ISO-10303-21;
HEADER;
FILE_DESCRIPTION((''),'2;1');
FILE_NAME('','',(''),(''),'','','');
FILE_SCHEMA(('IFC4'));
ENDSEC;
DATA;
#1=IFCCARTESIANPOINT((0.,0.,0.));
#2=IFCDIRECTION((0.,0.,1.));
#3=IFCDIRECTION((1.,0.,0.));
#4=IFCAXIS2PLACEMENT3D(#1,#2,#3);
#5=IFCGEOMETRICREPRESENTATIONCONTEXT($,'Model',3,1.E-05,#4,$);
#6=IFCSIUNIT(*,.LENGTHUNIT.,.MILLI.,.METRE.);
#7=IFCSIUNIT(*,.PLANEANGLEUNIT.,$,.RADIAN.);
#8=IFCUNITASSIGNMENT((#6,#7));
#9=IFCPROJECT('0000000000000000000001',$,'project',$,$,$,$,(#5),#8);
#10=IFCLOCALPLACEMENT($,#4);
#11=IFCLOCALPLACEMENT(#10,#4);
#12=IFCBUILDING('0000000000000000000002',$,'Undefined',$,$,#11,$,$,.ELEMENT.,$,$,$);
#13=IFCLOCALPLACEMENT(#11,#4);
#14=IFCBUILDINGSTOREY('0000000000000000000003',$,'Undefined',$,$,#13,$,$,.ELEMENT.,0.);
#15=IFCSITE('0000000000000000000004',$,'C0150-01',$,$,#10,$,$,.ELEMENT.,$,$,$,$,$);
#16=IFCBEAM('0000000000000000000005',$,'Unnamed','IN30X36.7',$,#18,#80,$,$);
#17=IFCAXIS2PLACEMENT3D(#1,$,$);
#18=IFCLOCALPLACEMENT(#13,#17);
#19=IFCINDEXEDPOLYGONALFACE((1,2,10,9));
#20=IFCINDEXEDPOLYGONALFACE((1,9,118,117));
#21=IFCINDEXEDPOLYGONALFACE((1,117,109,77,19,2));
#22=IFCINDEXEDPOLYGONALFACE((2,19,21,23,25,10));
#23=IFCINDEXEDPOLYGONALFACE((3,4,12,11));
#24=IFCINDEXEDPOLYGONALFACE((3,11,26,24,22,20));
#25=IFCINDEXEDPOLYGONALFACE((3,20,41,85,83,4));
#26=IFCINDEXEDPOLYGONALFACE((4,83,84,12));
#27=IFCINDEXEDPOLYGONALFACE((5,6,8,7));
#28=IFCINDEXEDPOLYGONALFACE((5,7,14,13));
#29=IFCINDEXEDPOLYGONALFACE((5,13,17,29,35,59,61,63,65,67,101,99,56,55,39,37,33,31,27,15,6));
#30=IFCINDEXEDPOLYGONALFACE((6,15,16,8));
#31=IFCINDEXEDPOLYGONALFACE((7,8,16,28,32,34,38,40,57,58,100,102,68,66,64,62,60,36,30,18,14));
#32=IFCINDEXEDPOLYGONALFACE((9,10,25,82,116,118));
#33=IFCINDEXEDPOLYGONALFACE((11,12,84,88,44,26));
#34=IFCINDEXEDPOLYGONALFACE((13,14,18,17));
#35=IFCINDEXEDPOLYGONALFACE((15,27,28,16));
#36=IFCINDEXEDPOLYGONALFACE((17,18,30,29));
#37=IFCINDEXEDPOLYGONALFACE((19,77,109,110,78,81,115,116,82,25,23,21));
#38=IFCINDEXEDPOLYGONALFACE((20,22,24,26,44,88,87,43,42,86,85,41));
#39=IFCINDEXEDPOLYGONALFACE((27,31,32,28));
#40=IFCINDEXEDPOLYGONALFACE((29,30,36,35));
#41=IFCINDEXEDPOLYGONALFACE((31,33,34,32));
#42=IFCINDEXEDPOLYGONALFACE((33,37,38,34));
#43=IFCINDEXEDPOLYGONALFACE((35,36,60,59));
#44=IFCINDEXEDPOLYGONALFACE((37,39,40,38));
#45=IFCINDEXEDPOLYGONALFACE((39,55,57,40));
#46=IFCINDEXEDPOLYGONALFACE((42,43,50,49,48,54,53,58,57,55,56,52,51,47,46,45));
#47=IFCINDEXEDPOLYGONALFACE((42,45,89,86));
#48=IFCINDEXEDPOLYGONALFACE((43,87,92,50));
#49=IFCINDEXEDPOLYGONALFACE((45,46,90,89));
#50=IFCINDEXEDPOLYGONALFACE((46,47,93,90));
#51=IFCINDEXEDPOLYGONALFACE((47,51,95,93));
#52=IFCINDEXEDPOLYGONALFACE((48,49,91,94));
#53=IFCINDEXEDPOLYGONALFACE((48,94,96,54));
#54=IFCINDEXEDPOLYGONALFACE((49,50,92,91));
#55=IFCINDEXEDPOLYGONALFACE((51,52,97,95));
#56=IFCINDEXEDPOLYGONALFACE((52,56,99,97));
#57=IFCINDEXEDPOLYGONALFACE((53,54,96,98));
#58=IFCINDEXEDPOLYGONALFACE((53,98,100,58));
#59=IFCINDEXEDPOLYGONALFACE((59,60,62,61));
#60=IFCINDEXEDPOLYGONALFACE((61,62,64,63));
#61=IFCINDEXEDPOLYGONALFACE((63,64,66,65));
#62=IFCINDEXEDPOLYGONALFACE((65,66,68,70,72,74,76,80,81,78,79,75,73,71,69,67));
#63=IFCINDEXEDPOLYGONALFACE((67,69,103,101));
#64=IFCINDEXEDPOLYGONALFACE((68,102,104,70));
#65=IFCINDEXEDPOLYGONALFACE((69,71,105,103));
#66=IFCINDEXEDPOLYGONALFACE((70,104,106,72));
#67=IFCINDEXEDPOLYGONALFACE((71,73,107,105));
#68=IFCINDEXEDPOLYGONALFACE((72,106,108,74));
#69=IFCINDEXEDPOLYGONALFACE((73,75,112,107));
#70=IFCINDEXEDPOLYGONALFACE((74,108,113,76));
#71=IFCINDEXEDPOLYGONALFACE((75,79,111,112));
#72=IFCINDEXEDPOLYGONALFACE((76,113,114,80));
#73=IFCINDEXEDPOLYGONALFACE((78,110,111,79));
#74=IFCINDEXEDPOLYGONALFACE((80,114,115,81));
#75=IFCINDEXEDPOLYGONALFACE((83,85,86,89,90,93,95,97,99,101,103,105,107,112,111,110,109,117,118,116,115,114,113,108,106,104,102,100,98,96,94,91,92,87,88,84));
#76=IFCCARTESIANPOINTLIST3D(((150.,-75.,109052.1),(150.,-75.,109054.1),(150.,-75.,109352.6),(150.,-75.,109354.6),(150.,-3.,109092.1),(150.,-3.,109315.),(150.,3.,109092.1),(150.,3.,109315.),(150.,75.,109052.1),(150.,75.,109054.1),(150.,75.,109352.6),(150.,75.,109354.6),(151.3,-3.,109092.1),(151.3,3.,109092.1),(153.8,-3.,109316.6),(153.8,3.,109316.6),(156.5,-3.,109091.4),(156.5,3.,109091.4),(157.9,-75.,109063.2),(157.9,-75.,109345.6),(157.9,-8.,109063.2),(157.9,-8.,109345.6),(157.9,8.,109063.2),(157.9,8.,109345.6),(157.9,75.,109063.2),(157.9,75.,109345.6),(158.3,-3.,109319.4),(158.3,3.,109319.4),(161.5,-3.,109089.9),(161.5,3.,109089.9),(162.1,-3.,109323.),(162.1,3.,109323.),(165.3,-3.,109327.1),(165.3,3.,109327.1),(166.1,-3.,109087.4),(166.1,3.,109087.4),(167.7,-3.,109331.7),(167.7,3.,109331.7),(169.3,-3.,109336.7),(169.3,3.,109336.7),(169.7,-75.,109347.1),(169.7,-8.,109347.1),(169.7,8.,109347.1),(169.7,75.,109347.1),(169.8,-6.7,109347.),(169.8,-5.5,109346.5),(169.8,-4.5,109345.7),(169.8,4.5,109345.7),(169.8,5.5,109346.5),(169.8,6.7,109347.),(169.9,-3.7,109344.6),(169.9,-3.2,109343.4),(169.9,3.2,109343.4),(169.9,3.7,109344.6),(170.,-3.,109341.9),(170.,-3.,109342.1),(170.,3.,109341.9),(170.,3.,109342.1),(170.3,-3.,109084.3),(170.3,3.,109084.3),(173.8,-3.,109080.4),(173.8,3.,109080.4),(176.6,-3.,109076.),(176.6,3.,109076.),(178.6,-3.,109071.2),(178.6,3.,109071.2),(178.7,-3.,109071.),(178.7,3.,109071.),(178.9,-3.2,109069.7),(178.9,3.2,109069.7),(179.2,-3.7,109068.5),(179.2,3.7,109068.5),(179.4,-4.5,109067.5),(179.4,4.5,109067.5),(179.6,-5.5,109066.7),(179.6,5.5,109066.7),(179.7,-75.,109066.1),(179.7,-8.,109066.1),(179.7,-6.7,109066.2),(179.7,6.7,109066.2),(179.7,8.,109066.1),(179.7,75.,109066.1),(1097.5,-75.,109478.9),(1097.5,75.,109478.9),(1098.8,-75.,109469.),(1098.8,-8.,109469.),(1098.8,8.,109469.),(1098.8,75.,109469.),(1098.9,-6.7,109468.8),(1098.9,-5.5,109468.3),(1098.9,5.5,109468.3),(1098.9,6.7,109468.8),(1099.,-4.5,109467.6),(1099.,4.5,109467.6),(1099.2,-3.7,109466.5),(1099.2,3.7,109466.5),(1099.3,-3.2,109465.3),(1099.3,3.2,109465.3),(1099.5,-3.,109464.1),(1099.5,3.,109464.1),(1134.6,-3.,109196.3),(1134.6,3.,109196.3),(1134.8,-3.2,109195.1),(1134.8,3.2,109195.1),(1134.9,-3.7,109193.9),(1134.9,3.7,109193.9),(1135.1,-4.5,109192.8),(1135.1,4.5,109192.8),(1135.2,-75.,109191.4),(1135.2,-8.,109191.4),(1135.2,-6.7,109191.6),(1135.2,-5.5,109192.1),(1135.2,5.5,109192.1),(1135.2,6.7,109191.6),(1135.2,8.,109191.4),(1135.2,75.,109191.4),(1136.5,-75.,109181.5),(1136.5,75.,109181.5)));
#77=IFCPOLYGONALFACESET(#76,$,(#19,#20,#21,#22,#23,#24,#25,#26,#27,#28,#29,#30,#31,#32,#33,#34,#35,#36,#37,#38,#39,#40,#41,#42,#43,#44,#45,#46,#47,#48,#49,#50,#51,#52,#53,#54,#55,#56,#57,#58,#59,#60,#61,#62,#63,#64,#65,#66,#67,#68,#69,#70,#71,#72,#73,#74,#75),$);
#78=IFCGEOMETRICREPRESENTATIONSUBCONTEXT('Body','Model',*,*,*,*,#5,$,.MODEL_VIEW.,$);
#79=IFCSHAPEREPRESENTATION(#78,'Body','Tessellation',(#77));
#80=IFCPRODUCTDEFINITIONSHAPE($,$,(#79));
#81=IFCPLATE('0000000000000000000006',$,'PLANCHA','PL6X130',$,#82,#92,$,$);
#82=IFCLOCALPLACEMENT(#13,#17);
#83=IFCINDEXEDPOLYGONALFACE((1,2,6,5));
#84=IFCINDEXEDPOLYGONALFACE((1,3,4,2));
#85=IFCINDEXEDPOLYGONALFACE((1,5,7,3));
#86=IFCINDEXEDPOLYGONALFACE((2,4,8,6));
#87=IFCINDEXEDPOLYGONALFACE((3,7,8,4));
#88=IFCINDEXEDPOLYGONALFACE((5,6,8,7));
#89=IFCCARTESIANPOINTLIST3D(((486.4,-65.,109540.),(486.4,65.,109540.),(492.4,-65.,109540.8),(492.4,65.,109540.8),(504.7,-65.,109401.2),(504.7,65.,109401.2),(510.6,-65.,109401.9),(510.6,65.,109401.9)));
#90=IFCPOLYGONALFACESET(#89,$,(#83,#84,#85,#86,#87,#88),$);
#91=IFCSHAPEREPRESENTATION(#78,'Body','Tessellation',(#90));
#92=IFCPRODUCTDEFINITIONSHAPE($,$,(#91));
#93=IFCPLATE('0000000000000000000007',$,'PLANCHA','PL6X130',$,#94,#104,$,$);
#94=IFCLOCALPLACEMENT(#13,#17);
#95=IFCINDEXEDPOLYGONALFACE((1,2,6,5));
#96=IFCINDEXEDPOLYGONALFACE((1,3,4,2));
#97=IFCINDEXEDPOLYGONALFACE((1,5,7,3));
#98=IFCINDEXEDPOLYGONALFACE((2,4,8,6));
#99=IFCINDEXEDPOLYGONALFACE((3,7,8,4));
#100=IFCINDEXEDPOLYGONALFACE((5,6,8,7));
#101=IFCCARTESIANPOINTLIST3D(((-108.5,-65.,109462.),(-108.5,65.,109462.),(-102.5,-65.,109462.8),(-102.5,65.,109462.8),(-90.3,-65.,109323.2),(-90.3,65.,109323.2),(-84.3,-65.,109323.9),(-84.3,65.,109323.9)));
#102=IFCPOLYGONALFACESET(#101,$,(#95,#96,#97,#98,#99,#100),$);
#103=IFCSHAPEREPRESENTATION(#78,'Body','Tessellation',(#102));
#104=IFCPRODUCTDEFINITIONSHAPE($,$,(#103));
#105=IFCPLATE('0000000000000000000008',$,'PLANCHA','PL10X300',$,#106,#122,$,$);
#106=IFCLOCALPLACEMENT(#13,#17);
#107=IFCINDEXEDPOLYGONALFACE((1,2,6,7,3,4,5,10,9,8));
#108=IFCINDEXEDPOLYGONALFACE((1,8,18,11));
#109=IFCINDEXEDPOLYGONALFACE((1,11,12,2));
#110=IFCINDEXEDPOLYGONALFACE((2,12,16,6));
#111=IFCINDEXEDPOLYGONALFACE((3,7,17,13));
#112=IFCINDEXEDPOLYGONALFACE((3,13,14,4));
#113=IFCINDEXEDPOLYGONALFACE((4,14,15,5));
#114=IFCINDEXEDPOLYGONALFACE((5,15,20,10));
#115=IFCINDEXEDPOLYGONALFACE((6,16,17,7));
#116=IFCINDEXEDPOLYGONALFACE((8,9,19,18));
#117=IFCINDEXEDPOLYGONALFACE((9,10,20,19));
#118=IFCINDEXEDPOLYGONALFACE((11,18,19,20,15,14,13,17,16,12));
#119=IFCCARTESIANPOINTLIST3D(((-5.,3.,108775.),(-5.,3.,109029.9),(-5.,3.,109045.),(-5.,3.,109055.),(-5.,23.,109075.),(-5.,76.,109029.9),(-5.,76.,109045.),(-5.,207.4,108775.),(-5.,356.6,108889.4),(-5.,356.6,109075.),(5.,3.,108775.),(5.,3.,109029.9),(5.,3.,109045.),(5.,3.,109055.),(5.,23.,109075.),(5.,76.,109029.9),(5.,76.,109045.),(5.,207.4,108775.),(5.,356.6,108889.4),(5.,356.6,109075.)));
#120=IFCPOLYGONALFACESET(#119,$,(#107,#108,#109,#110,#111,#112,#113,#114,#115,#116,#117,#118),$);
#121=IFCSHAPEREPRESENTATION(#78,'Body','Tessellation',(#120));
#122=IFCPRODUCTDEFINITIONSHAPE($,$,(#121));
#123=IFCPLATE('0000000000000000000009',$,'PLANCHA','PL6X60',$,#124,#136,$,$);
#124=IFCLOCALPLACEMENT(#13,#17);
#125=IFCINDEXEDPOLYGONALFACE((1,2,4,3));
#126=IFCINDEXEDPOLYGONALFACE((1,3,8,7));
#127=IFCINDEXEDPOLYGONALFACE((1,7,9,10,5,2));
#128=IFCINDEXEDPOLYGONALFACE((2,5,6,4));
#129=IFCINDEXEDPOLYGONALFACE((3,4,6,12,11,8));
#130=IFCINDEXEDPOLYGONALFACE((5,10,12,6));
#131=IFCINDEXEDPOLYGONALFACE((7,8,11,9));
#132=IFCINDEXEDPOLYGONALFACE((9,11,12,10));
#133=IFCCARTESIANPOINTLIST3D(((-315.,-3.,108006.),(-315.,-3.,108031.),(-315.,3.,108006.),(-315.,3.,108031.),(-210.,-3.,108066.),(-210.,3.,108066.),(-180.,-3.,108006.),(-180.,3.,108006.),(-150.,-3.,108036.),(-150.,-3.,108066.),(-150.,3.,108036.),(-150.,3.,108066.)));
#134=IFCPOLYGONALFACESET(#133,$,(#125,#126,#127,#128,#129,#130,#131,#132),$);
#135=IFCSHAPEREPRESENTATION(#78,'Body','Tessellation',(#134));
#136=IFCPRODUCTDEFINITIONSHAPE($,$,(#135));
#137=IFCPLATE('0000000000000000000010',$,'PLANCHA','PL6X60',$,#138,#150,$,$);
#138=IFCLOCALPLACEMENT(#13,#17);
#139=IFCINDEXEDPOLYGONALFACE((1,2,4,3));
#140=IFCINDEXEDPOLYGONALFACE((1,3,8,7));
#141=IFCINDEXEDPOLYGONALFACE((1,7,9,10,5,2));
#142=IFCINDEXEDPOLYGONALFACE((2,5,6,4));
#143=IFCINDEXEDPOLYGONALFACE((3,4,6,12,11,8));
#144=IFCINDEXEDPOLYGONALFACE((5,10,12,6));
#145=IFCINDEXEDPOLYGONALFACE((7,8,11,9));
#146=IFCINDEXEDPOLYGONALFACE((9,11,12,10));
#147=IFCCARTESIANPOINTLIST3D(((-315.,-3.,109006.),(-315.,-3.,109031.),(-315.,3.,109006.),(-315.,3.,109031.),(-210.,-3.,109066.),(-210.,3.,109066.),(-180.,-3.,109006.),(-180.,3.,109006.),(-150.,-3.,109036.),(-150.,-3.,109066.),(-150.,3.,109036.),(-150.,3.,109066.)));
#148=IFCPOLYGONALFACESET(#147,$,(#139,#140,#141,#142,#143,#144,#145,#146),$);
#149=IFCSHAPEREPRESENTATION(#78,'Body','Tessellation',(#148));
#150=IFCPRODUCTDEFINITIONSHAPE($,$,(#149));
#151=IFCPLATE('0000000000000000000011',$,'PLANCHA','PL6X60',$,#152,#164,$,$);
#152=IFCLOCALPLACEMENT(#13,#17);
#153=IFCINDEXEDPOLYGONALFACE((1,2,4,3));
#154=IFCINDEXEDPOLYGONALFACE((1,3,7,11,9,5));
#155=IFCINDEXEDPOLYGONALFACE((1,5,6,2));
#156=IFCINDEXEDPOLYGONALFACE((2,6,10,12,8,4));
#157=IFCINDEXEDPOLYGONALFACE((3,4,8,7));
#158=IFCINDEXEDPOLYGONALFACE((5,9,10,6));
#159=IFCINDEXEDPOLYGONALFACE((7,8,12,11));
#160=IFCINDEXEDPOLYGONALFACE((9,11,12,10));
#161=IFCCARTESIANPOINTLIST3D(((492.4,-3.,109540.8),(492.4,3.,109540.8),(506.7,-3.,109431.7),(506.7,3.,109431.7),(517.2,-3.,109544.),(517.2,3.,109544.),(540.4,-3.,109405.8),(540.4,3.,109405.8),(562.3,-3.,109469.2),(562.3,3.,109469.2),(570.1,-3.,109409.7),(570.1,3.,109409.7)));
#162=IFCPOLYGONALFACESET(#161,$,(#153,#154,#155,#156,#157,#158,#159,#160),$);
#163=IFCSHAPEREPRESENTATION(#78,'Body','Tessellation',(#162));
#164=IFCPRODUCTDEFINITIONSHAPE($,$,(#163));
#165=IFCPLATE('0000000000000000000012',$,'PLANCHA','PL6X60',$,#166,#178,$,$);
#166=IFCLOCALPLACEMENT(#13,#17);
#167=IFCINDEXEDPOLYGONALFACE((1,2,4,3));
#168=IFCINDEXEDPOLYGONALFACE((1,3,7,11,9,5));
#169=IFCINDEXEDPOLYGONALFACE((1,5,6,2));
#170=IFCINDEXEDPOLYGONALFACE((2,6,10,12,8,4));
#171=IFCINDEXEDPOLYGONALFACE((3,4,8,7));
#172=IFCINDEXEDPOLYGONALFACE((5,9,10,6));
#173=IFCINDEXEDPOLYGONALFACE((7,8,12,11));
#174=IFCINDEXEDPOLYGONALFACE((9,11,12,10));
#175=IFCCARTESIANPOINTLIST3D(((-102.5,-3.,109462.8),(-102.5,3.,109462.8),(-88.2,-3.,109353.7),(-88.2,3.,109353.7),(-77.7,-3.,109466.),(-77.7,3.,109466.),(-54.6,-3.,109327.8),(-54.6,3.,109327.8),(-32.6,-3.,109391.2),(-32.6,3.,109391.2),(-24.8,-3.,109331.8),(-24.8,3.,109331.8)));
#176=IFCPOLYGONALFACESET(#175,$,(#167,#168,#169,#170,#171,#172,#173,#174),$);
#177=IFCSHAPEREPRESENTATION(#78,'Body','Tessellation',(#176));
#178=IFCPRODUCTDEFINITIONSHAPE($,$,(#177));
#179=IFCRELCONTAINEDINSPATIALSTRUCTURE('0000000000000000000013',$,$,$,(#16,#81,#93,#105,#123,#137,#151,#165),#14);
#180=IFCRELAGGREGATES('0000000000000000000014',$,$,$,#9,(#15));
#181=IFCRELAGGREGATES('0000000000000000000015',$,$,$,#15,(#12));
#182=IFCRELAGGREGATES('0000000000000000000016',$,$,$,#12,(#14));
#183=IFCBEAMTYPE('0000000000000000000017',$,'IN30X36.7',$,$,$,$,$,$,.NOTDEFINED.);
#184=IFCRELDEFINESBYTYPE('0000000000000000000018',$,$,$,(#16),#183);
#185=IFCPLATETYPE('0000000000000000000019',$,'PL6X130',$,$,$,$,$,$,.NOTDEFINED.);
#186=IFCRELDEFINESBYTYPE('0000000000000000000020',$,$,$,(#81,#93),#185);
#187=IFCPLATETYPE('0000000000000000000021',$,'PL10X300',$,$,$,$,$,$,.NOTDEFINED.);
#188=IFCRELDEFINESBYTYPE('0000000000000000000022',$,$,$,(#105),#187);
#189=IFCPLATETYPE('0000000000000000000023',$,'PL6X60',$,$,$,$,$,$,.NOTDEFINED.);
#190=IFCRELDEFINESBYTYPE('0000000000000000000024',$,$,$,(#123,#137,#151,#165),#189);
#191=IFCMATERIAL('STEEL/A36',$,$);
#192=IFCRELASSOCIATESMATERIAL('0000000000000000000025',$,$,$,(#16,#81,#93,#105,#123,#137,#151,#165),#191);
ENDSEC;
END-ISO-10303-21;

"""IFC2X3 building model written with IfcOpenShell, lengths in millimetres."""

from ifc_helpers import new_model, si_unit, frame, origin_with_axes, origin_2d_with_axis, place, context, subcontext, project, spatial, polyline, i_section, outline, extrude, boolean, halfspace, material, type_object, element, save


model = new_model("IFC2X3")

# Units and contexts
model_context = context("Model", 3, precision=1e-05, world=origin_with_axes())
body_context = subcontext(model_context, "Body", "Model", "MODEL_VIEW")
ifc_project = project(units=[si_unit("LENGTHUNIT", "METRE", prefix="MILLI"), si_unit("PLANEANGLEUNIT", "RADIAN")], contexts=[model_context])

# Site, building, storey
site_placement = place(None, origin_with_axes())
site = spatial("IfcSite", under=ifc_project, at=site_placement, Name="C0150-01", CompositionType="ELEMENT")
building_placement = place(site_placement, origin_with_axes())
building = spatial("IfcBuilding", under=site, at=building_placement, Name="Undefined", CompositionType="ELEMENT")
storey_placement = place(building_placement, origin_with_axes())
storey = spatial("IfcBuildingStorey", under=building, at=storey_placement, Name="Undefined", CompositionType="ELEMENT", Elevation=0.0)

# Shared definitions
ifc_material_1 = material(Name="STEEL/A36")

# Beam
beam_type_1 = type_object("IfcBeamType", Name="IN30X36.7", PredefinedType="NOTDEFINED")
beam_1_placement = place(storey_placement, frame((0.0, 0.0, 109183.7), z_axis=(-0.130054, 0.0, 0.991507), x_axis=(0.991507, 0.0, 0.130054)))
element("IfcBeam", 1, at=beam_1_placement, inside=storey, type_object=beam_type_1, material=ifc_material_1, Name="Unnamed", Description="IN30X36.7", context=body_context, shape_type="CSG", body=[
    boolean("DIFFERENCE", boolean("DIFFERENCE", boolean("DIFFERENCE", boolean("DIFFERENCE", boolean("DIFFERENCE", extrude(i_section(OverallWidth=150.0, OverallDepth=300.0, WebThickness=6.0, FlangeThickness=10.0, FilletRadius=5.0, at=origin_2d_with_axis()), frame((1126.6, 0.0, 0.0), z_axis=(-1.0, 0.0, 0.0), x_axis=(0.0, -1.0, 0.0)), (0.0, 0.0, 1.0), 1126.6), extrude(outline(polyline([(0.0, 0.0), (12.1, 0.0), (6.0, 5.3), (0.0, 0.0)])), frame((140.9, -77.5, -140.0), z_axis=(0.0, 1.0, 0.0), x_axis=(-0.748593, 0.0, -0.66303)), (0.0, 0.0, 1.0), 155.0)), extrude(outline(polyline([(0.0, 0.0), (8.0, 0.0), (6.9, 8.0), (0.0, 0.0)])), frame((177.6, -77.5, 140.0), z_axis=(0.0, 1.0, 0.0), x_axis=(-1.0, 0.0, 0.0)), (0.0, 0.0, 1.0), 155.0)), extrude(outline(polyline([(0.0, 0.0), (30.0, 0.0), (30.0, 0.0), (29.5, 5.2), (28.2, 10.3), (26.0, 15.0), (23.0, 19.3), (19.3, 23.0), (15.0, 26.0), (10.3, 28.2), (5.2, 29.5), (0.0, 30.0), (3.9, 30.0), (0.0, 0.0)])), frame((159.6, -77.5, 140.0), z_axis=(0.0, 1.0, 0.0), x_axis=(1.0, 0.0, 0.0)), (0.0, 0.0, 1.0), 155.0)), extrude(outline(polyline([(0.0, 0.0), (30.0, 0.0), (30.0, 0.0), (29.5, 5.2), (28.2, 10.3), (26.0, 15.0), (23.0, 19.3), (19.3, 23.0), (15.0, 26.0), (10.3, 28.2), (5.2, 29.5), (0.0, 30.0), (3.9, 30.0), (0.0, 0.0)])), frame((132.9, 77.5, -140.0), z_axis=(0.0, -1.0, 0.0), x_axis=(1.0, 0.0, 0.0)), (0.0, 0.0, 1.0), 155.0)), halfspace(frame((124.8, 0.0, -201.6), z_axis=(0.991507, 0.0, -0.130054), x_axis=(0.0, -1.0, 0.0)), True)),
])

# Plates
plate_type_1 = type_object("IfcPlateType", Name="PL6X130", PredefinedType="NOTDEFINED")
for number, where, z_axis, x_axis, name in (
    (2, (507.6, -65.0, 109401.5), (0.991507, 0.0, 0.130054), (0.0, 1.0, 0.0), "PLANCHA"),
    (3, (-87.3, 65.0, 109323.6), (-0.991507, 0.0, -0.130054), (0.0, -1.0, 0.0), "PLANCHA"),
):
    element("IfcPlate", number, at=place(storey_placement, frame(where, z_axis=z_axis, x_axis=x_axis)), inside=storey, type_object=plate_type_1, material=ifc_material_1, Name=name, Description="PL6X130", context=body_context, shape_type="SweptSolid", body=[
        extrude(outline(polyline([(0.0, 0.0), (130.0, 0.0), (130.0, 140.0), (0.0, 140.0), (0.0, 0.0)])), frame((0.0, 0.0, -3.0), z_axis=(0.0, 0.0, 1.0), x_axis=(1.0, 0.0, 0.0)), (0.0, 0.0, 1.0), 6.0),
    ])
plate_type_2 = type_object("IfcPlateType", Name="PL10X300", PredefinedType="NOTDEFINED")
plate_1_placement = place(storey_placement, frame((0.0, 356.6, 109075.0), z_axis=(-1.0, 0.0, 0.0), x_axis=(0.0, 0.0, -1.0)))
element("IfcPlate", 4, at=plate_1_placement, inside=storey, type_object=plate_type_2, material=ifc_material_1, Name="PLANCHA", Description="PL10X300", context=body_context, shape_type="SweptSolid", body=[
    extrude(outline(polyline([(0.0, 0.0), (185.6, 0.0), (300.0, 149.2), (300.0, 353.6), (45.1, 353.6), (45.1, 280.6), (30.0, 280.6), (30.0, 353.6), (20.0, 353.6), (0.0, 333.6), (0.0, 0.0)])), frame((0.0, 0.0, -5.0), z_axis=(0.0, 0.0, 1.0), x_axis=(1.0, 0.0, 0.0)), (0.0, 0.0, 1.0), 10.0),
])
plate_type_3 = type_object("IfcPlateType", Name="PL6X60", PredefinedType="NOTDEFINED")
for number, where, z_axis, x_axis, name in (
    (5, (-315.0, 0.0, 108031.0), (0.0, -1.0, 0.0), (-0.000004, 0.0, -1.0), "PLANCHA"),
    (6, (-315.0, 0.0, 109031.0), (0.0, -1.0, 0.0), (-0.000004, 0.0, -1.0), "PLANCHA"),
):
    element("IfcPlate", number, at=place(storey_placement, frame(where, z_axis=z_axis, x_axis=x_axis)), inside=storey, type_object=plate_type_3, material=ifc_material_1, Name=name, Description="PL6X60", context=body_context, shape_type="SweptSolid", body=[
        extrude(outline(polyline([(0.0, 0.0), (25.0, 0.0), (25.0, 135.0), (-5.0, 165.0), (-35.0, 165.0), (-35.0, 105.0), (0.0, 0.0)])), frame((0.0, 0.0, -3.0), z_axis=(0.0, 0.0, 1.0), x_axis=(1.0, 0.0, 0.0)), (0.0, 0.0, 1.0), 6.0),
    ])
for number, where, z_axis, x_axis, name in (
    (7, (517.2, 0.0, 109544.0), (0.0, -1.0, 0.0), (-0.991507, 0.0, -0.130054), "PLANCHA"),
    (8, (-77.7, 0.0, 109466.0), (0.0, -1.0, 0.0), (-0.991507, 0.0, -0.130054), "PLANCHA"),
):
    element("IfcPlate", number, at=place(storey_placement, frame(where, z_axis=z_axis, x_axis=x_axis)), inside=storey, type_object=plate_type_3, material=ifc_material_1, Name=name, Description="PL6X60", context=body_context, shape_type="SweptSolid", body=[
        extrude(outline(polyline([(0.0, 0.0), (25.0, 0.0), (25.0, 110.0), (-5.0, 140.0), (-35.0, 140.0), (-35.0, 80.0), (0.0, 0.0)])), frame((0.0, 0.0, -3.0), z_axis=(0.0, 0.0, 1.0), x_axis=(1.0, 0.0, 0.0)), (0.0, 0.0, 1.0), 6.0),
    ])

save(model, "model.ifc")
